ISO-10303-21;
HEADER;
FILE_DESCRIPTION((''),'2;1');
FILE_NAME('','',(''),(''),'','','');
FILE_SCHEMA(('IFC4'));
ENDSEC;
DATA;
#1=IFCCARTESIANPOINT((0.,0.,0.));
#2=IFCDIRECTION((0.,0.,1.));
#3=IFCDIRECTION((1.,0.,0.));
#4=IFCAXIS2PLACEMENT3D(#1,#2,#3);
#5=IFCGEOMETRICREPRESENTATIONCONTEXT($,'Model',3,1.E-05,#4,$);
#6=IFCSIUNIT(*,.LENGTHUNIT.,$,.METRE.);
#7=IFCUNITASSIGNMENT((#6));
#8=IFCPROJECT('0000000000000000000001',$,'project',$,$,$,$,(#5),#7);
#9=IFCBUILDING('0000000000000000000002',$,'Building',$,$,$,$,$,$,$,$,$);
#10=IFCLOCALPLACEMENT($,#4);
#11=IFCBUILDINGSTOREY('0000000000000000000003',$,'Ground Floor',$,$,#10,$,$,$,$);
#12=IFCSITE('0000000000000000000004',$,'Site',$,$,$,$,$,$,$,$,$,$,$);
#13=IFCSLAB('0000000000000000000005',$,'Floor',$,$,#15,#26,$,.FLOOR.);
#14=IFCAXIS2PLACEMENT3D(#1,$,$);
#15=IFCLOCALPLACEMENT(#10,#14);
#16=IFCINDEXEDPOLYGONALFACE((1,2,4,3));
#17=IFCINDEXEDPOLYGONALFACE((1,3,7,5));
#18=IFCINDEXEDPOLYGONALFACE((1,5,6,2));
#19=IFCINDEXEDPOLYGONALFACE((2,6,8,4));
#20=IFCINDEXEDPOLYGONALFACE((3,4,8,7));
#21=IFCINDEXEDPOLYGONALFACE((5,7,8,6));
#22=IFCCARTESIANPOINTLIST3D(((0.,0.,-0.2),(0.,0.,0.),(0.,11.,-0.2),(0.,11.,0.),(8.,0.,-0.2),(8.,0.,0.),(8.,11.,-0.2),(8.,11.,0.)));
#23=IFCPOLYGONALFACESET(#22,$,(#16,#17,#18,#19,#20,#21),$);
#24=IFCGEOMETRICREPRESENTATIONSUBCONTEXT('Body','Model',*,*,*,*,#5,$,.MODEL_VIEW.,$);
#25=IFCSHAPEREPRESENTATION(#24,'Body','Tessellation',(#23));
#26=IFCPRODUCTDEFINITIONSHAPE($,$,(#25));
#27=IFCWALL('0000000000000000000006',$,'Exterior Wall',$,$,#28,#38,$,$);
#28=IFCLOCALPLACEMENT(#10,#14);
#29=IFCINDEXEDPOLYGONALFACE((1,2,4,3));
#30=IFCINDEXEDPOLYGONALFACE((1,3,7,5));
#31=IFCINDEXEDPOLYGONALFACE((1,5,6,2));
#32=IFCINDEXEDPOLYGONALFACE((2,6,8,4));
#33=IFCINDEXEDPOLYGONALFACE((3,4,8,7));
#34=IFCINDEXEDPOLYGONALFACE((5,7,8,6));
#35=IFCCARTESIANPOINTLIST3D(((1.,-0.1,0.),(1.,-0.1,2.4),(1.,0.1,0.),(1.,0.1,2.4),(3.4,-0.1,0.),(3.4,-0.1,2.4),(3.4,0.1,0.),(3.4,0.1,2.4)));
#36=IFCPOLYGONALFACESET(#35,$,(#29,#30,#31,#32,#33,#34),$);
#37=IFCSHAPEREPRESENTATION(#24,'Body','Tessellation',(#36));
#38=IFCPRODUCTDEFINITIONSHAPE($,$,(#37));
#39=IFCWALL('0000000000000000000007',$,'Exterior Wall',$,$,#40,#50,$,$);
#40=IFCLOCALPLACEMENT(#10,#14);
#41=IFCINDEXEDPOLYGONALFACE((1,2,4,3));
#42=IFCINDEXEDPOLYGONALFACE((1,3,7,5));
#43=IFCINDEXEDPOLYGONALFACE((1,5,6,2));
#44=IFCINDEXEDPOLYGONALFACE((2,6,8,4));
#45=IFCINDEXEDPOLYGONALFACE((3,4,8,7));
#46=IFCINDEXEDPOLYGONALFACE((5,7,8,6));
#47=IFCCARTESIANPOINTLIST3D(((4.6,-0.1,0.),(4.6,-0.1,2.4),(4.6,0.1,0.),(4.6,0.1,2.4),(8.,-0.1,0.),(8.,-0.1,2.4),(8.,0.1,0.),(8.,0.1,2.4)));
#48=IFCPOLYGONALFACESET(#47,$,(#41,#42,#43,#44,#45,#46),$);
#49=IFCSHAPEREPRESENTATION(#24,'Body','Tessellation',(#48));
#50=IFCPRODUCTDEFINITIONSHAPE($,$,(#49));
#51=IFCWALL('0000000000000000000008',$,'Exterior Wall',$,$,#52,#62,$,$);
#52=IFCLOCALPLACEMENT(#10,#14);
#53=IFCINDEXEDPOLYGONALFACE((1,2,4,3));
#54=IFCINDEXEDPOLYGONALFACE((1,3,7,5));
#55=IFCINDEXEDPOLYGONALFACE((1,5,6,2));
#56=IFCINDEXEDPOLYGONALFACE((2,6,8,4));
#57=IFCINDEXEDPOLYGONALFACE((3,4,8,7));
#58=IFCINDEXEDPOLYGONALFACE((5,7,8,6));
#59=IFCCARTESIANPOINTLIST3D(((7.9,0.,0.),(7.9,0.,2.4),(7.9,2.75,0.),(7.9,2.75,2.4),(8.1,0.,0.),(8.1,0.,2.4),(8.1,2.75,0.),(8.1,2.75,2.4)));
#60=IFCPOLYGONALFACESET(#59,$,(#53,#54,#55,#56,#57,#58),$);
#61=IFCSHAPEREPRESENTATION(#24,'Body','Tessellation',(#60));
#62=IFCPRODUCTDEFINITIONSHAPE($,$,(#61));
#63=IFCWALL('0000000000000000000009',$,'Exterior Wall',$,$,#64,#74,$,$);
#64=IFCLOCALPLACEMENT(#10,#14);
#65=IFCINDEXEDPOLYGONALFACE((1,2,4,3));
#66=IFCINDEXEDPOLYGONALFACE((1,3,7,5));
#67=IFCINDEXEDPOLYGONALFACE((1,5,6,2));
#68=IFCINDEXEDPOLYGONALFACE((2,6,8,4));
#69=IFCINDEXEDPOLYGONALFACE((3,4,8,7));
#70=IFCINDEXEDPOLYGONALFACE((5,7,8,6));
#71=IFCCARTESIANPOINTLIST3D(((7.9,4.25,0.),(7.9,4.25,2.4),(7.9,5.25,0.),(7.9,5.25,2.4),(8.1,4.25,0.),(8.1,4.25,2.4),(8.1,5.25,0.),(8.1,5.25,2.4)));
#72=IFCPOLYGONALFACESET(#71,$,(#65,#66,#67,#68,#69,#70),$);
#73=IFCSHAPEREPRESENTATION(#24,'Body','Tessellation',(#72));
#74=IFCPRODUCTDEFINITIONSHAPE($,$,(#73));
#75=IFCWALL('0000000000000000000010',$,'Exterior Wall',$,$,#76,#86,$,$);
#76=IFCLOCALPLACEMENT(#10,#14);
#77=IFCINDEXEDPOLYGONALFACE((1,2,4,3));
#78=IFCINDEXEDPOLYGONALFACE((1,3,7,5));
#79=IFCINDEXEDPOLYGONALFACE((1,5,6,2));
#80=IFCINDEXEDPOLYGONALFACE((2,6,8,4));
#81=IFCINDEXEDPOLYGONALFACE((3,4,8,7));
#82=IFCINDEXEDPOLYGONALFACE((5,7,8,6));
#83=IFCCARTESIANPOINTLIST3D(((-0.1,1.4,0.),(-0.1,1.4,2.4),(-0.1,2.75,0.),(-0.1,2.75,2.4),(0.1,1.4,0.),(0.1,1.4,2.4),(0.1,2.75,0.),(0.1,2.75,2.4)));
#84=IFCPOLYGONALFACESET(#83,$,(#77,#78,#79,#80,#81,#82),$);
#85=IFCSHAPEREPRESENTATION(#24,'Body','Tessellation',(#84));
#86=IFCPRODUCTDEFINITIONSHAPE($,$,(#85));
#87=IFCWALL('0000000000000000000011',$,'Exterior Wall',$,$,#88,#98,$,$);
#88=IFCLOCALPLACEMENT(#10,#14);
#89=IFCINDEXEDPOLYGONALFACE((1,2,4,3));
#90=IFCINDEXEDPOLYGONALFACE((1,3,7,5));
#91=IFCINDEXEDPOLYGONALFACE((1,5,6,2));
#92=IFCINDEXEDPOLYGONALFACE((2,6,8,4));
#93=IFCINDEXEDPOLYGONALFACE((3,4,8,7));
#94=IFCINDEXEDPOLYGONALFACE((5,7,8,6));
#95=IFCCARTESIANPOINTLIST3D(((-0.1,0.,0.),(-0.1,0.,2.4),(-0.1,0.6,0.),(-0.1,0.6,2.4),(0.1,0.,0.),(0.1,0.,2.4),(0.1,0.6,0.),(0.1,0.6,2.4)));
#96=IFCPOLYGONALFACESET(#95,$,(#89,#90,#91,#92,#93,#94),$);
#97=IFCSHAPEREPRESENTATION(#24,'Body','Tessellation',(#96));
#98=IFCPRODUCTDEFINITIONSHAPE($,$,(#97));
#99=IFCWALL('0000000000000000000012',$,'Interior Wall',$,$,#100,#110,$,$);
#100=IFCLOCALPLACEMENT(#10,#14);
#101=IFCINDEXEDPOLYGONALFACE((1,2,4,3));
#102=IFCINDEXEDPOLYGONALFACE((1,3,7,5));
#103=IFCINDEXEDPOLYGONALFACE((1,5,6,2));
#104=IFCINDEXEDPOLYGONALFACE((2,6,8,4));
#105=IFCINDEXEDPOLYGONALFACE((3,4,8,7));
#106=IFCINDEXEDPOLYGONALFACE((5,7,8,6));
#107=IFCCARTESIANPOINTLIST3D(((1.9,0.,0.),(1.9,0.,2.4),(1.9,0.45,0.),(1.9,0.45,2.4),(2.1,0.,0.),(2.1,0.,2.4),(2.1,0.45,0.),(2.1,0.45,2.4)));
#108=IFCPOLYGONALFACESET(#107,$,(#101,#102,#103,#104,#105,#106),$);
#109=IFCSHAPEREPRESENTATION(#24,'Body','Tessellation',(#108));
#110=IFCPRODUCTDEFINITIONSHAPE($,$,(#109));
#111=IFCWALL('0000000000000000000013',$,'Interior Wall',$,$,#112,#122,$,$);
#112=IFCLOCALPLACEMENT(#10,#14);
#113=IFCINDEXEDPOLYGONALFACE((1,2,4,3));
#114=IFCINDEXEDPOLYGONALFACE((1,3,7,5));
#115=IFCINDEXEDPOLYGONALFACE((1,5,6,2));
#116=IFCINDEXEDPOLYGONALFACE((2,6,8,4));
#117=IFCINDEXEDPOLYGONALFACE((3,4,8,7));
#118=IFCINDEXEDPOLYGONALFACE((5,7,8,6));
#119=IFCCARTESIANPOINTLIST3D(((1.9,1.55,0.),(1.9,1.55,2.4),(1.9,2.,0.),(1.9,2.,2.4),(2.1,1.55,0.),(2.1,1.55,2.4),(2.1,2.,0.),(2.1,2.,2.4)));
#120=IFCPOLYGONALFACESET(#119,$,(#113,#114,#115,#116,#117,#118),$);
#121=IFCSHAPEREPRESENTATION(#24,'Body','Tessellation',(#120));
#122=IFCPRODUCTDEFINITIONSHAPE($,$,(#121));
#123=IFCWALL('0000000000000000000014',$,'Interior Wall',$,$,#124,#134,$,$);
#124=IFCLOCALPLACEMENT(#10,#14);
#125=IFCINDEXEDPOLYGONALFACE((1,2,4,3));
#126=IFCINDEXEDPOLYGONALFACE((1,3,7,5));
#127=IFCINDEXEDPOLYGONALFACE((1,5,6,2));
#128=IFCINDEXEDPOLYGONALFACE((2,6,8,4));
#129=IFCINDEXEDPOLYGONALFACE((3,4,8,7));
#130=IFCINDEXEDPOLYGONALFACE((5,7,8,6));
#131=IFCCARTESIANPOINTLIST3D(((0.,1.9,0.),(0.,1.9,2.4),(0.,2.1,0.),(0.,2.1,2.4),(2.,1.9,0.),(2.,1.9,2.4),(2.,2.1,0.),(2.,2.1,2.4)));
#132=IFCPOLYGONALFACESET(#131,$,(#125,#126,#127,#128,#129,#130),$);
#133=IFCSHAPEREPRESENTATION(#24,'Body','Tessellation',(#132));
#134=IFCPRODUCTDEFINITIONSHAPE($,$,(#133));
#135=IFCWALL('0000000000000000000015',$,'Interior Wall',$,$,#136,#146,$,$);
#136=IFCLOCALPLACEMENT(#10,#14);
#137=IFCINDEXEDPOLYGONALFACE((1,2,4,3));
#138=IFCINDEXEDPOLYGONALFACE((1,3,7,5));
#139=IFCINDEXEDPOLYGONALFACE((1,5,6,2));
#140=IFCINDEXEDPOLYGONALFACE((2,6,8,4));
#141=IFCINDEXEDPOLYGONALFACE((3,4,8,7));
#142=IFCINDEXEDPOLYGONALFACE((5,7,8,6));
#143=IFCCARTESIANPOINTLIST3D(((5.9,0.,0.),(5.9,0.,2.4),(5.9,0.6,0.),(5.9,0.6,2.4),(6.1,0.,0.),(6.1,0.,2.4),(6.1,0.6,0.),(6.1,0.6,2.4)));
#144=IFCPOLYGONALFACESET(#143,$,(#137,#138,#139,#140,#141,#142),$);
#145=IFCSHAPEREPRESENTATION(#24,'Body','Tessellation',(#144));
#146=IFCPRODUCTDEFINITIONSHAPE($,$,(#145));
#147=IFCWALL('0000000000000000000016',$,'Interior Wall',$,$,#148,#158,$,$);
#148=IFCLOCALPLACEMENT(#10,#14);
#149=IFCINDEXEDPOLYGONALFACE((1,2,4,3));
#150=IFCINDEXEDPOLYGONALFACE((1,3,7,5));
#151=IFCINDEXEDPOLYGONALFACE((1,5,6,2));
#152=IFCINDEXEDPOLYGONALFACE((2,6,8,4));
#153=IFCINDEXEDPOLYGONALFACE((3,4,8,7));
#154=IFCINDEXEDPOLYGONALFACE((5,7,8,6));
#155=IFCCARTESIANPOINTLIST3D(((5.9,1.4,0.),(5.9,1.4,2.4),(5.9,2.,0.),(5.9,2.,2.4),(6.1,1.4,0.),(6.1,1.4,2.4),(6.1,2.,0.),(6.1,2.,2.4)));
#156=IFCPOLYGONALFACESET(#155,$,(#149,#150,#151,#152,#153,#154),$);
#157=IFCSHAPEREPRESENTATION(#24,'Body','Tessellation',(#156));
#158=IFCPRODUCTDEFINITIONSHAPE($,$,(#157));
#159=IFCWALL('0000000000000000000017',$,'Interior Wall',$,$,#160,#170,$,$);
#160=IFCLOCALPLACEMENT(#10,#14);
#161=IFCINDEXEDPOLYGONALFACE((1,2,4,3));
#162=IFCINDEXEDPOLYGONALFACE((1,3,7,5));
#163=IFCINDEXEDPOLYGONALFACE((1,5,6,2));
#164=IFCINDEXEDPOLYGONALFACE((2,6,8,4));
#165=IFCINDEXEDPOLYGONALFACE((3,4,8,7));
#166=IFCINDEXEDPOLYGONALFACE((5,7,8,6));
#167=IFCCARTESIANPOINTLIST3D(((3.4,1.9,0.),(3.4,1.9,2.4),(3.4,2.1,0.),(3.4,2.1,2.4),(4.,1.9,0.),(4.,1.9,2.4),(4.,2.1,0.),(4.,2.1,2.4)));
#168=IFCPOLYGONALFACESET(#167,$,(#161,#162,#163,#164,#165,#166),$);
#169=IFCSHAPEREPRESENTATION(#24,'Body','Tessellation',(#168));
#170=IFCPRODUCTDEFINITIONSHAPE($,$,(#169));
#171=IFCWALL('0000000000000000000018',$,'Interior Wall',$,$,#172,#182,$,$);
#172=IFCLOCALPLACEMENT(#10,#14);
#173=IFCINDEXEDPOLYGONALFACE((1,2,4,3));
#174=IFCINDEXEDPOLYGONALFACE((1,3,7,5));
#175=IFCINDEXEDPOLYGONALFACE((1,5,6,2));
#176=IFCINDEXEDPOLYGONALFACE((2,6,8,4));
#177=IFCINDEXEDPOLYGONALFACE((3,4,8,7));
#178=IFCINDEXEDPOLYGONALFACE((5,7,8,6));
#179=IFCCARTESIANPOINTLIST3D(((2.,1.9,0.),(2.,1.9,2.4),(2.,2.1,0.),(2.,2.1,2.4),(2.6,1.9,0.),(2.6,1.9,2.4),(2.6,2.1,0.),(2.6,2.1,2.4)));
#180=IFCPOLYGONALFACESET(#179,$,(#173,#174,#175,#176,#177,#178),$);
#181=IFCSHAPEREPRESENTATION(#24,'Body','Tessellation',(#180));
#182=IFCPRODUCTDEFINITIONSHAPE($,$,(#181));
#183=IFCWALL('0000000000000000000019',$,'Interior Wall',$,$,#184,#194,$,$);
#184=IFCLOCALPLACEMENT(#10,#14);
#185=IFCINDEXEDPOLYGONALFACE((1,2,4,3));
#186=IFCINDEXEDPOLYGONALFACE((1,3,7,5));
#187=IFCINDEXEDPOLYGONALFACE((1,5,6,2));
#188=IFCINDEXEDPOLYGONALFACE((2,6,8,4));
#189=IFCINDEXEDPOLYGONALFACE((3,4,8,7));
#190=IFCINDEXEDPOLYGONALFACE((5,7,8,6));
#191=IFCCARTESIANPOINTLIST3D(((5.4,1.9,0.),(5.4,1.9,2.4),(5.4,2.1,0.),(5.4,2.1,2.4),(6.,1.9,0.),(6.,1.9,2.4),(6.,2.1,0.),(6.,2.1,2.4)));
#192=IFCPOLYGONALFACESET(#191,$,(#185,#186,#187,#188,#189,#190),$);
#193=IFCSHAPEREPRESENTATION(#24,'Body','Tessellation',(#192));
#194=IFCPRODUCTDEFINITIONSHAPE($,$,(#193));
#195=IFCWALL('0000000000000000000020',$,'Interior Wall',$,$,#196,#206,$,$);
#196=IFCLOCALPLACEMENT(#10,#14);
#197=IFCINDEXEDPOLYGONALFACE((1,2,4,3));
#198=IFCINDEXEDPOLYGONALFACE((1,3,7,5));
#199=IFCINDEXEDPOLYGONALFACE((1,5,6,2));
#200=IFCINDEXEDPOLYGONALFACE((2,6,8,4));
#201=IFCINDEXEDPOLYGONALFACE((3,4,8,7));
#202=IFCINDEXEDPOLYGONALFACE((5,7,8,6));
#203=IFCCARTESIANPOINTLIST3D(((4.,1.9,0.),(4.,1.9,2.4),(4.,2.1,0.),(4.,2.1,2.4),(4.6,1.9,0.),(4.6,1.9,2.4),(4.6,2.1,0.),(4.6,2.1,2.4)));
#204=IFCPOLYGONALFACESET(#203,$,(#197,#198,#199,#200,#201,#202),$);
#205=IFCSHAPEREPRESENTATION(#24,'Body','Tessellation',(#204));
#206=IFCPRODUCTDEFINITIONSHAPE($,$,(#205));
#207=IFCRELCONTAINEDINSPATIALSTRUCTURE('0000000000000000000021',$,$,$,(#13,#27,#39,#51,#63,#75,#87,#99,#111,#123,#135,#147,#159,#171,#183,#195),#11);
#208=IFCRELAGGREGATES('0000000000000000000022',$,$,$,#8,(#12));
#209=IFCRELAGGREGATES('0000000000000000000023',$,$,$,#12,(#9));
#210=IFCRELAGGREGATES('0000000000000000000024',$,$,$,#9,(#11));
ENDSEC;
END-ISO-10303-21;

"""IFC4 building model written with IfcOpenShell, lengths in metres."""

from ifc_helpers import new_model, si_unit, frame, origin_with_axes, place, context, subcontext, project, spatial, indexed_curve, outline, extrude, element, save


model = new_model("IFC4")

# Units and contexts
model_context = context("Model", 3, precision=1e-05, world=origin_with_axes())
body_context = subcontext(model_context, "Body", "Model", "MODEL_VIEW")
ifc_project = project(units=[si_unit("LENGTHUNIT", "METRE")], contexts=[model_context])

# Site, building, storey
site = spatial("IfcSite", under=ifc_project, Name="Site")
building = spatial("IfcBuilding", under=site, Name="Building")
storey_placement = place(None, origin_with_axes())
storey = spatial("IfcBuildingStorey", under=building, at=storey_placement, Name="Ground Floor")

# Slab
slab_placement = place(storey_placement, frame((0.0, 0.0, -0.2), z_axis=(0.0, 0.0, 1.0), x_axis=(1.0, 0.0, 0.0)))
element("IfcSlab", 1, at=slab_placement, inside=storey, Name="Floor", PredefinedType="FLOOR", context=body_context, shape_type="SweptSolid", body=[
    extrude(outline(indexed_curve([(0.0, 0.0), (8.0, 0.0), (8.0, 11.0), (0.0, 11.0)])), None, (0.0, 0.0, 1.0), 0.2),
])

# Walls
wall_1_placement = place(storey_placement, frame((1.0, 0.0, 0.0), z_axis=(0.0, 0.0, 1.0), x_axis=(1.0, 0.0, 0.0)))
element("IfcWall", 2, at=wall_1_placement, inside=storey, Name="Exterior Wall", context=body_context, shape_type="SweptSolid", body=[
    extrude(outline(indexed_curve([(0.0, 0.0), (0.0, 0.2), (2.4, 0.2), (2.4, 0.0), (0.0, 0.0)], self_intersect=False)), frame((0.0, -0.1, 0.0), z_axis=(0.0, 0.0, 1.0), x_axis=(1.0, 0.0, 0.0)), (0.0, 0.0, 1.0), 2.4),
])
wall_2_placement = place(storey_placement, frame((4.6, 0.0, 0.0), z_axis=(0.0, 0.0, 1.0), x_axis=(1.0, 0.0, 0.0)))
element("IfcWall", 3, at=wall_2_placement, inside=storey, Name="Exterior Wall", context=body_context, shape_type="SweptSolid", body=[
    extrude(outline(indexed_curve([(0.0, 0.0), (0.0, 0.2), (3.4, 0.2), (3.4, 0.0), (0.0, 0.0)], self_intersect=False)), frame((0.0, -0.1, 0.0), z_axis=(0.0, 0.0, 1.0), x_axis=(1.0, 0.0, 0.0)), (0.0, 0.0, 1.0), 2.4),
])
wall_3_placement = place(storey_placement, frame((8.0, 0.0, 0.0), z_axis=(0.0, 0.0, 1.0), x_axis=(0.0, 1.0, 0.0)))
element("IfcWall", 4, at=wall_3_placement, inside=storey, Name="Exterior Wall", context=body_context, shape_type="SweptSolid", body=[
    extrude(outline(indexed_curve([(0.0, 0.0), (0.0, 0.2), (2.75, 0.2), (2.75, 0.0), (0.0, 0.0)], self_intersect=False)), frame((0.0, -0.1, 0.0), z_axis=(0.0, 0.0, 1.0), x_axis=(1.0, 0.0, 0.0)), (0.0, 0.0, 1.0), 2.4),
])
wall_4_placement = place(storey_placement, frame((8.0, 4.25, 0.0), z_axis=(0.0, 0.0, 1.0), x_axis=(0.0, 1.0, 0.0)))
element("IfcWall", 5, at=wall_4_placement, inside=storey, Name="Exterior Wall", context=body_context, shape_type="SweptSolid", body=[
    extrude(outline(indexed_curve([(0.0, 0.0), (0.0, 0.2), (1.0, 0.2), (1.0, 0.0), (0.0, 0.0)], self_intersect=False)), frame((0.0, -0.1, 0.0), z_axis=(0.0, 0.0, 1.0), x_axis=(1.0, 0.0, 0.0)), (0.0, 0.0, 1.0), 2.4),
])
wall_5_placement = place(storey_placement, frame((0.0, 2.75, 0.0), z_axis=(0.0, 0.0, 1.0), x_axis=(0.0, -1.0, 0.0)))
element("IfcWall", 6, at=wall_5_placement, inside=storey, Name="Exterior Wall", context=body_context, shape_type="SweptSolid", body=[
    extrude(outline(indexed_curve([(0.0, 0.0), (0.0, 0.2), (1.35, 0.2), (1.35, 0.0), (0.0, 0.0)], self_intersect=False)), frame((0.0, -0.1, 0.0), z_axis=(0.0, 0.0, 1.0), x_axis=(1.0, 0.0, 0.0)), (0.0, 0.0, 1.0), 2.4),
])
wall_6_placement = place(storey_placement, frame((0.0, 0.6, 0.0), z_axis=(0.0, 0.0, 1.0), x_axis=(0.0, -1.0, 0.0)))
element("IfcWall", 7, at=wall_6_placement, inside=storey, Name="Exterior Wall", context=body_context, shape_type="SweptSolid", body=[
    extrude(outline(indexed_curve([(0.0, 0.0), (0.0, 0.2), (0.6, 0.2), (0.6, 0.0), (0.0, 0.0)], self_intersect=False)), frame((0.0, -0.1, 0.0), z_axis=(0.0, 0.0, 1.0), x_axis=(1.0, 0.0, 0.0)), (0.0, 0.0, 1.0), 2.4),
])
for number, where, z_axis, x_axis, name in (
    (8, (2.0, 0.0, 0.0), (0.0, 0.0, 1.0), (0.0, 1.0, 0.0), "Interior Wall"),
    (9, (2.0, 1.55, 0.0), (0.0, 0.0, 1.0), (0.0, 1.0, 0.0), "Interior Wall"),
):
    element("IfcWall", number, at=place(storey_placement, frame(where, z_axis=z_axis, x_axis=x_axis)), inside=storey, Name=name, context=body_context, shape_type="SweptSolid", body=[
        extrude(outline(indexed_curve([(0.0, 0.0), (0.0, 0.2), (0.45, 0.2), (0.45, 0.0), (0.0, 0.0)], self_intersect=False)), frame((0.0, -0.1, 0.0), z_axis=(0.0, 0.0, 1.0), x_axis=(1.0, 0.0, 0.0)), (0.0, 0.0, 1.0), 2.4),
    ])
wall_7_placement = place(storey_placement, frame((2.0, 2.0, 0.0), z_axis=(0.0, 0.0, 1.0), x_axis=(-1.0, 0.0, 0.0)))
element("IfcWall", 10, at=wall_7_placement, inside=storey, Name="Interior Wall", context=body_context, shape_type="SweptSolid", body=[
    extrude(outline(indexed_curve([(0.0, 0.0), (0.0, 0.2), (2.0, 0.2), (2.0, 0.0), (0.0, 0.0)], self_intersect=False)), frame((0.0, -0.1, 0.0), z_axis=(0.0, 0.0, 1.0), x_axis=(1.0, 0.0, 0.0)), (0.0, 0.0, 1.0), 2.4),
])
wall_8_placement = place(storey_placement, frame((6.0, 0.0, 0.0), z_axis=(0.0, 0.0, 1.0), x_axis=(0.0, 1.0, 0.0)))
element("IfcWall", 11, at=wall_8_placement, inside=storey, Name="Interior Wall", context=body_context, shape_type="SweptSolid", body=[
    extrude(outline(indexed_curve([(0.0, 0.0), (0.0, 0.2), (0.6, 0.2), (0.6, 0.0), (0.0, 0.0)], self_intersect=False)), frame((0.0, -0.1, 0.0), z_axis=(0.0, 0.0, 1.0), x_axis=(1.0, 0.0, 0.0)), (0.0, 0.0, 1.0), 2.4),
])
for number, where, z_axis, x_axis, name in (
    (12, (6.0, 1.4, 0.0), (0.0, 0.0, 1.0), (0.0, 1.0, 0.0), "Interior Wall"),
    (13, (4.0, 2.0, 0.0), (0.0, 0.0, 1.0), (-1.0, 0.0, 0.0), "Interior Wall"),
    (14, (2.6, 2.0, 0.0), (0.0, 0.0, 1.0), (-1.0, 0.0, 0.0), "Interior Wall"),
):
    element("IfcWall", number, at=place(storey_placement, frame(where, z_axis=z_axis, x_axis=x_axis)), inside=storey, Name=name, context=body_context, shape_type="SweptSolid", body=[
        extrude(outline(indexed_curve([(0.0, 0.0), (0.0, 0.2), (0.6, 0.2), (0.6, 0.0), (0.0, 0.0)], self_intersect=False)), frame((0.0, -0.1, 0.0), z_axis=(0.0, 0.0, 1.0), x_axis=(1.0, 0.0, 0.0)), (0.0, 0.0, 1.0), 2.4),
    ])
for number, where, z_axis, x_axis, name in (
    (15, (6.0, 2.0, 0.0), (0.0, 0.0, 1.0), (-1.0, 0.0, 0.0), "Interior Wall"),
    (16, (4.6, 2.0, 0.0), (0.0, 0.0, 1.0), (-1.0, 0.0, 0.0), "Interior Wall"),
):
    element("IfcWall", number, at=place(storey_placement, frame(where, z_axis=z_axis, x_axis=x_axis)), inside=storey, Name=name, context=body_context, shape_type="SweptSolid", body=[
        extrude(outline(indexed_curve([(0.0, 0.0), (0.0, 0.2), (0.6, 0.2), (0.6, 0.0), (0.0, 0.0)], self_intersect=False)), frame((0.0, -0.1, 0.0), z_axis=(0.0, 0.0, 1.0), x_axis=(1.0, 0.0, 0.0)), (0.0, 0.0, 1.0), 2.4),
    ])

save(model, "model.ifc")
